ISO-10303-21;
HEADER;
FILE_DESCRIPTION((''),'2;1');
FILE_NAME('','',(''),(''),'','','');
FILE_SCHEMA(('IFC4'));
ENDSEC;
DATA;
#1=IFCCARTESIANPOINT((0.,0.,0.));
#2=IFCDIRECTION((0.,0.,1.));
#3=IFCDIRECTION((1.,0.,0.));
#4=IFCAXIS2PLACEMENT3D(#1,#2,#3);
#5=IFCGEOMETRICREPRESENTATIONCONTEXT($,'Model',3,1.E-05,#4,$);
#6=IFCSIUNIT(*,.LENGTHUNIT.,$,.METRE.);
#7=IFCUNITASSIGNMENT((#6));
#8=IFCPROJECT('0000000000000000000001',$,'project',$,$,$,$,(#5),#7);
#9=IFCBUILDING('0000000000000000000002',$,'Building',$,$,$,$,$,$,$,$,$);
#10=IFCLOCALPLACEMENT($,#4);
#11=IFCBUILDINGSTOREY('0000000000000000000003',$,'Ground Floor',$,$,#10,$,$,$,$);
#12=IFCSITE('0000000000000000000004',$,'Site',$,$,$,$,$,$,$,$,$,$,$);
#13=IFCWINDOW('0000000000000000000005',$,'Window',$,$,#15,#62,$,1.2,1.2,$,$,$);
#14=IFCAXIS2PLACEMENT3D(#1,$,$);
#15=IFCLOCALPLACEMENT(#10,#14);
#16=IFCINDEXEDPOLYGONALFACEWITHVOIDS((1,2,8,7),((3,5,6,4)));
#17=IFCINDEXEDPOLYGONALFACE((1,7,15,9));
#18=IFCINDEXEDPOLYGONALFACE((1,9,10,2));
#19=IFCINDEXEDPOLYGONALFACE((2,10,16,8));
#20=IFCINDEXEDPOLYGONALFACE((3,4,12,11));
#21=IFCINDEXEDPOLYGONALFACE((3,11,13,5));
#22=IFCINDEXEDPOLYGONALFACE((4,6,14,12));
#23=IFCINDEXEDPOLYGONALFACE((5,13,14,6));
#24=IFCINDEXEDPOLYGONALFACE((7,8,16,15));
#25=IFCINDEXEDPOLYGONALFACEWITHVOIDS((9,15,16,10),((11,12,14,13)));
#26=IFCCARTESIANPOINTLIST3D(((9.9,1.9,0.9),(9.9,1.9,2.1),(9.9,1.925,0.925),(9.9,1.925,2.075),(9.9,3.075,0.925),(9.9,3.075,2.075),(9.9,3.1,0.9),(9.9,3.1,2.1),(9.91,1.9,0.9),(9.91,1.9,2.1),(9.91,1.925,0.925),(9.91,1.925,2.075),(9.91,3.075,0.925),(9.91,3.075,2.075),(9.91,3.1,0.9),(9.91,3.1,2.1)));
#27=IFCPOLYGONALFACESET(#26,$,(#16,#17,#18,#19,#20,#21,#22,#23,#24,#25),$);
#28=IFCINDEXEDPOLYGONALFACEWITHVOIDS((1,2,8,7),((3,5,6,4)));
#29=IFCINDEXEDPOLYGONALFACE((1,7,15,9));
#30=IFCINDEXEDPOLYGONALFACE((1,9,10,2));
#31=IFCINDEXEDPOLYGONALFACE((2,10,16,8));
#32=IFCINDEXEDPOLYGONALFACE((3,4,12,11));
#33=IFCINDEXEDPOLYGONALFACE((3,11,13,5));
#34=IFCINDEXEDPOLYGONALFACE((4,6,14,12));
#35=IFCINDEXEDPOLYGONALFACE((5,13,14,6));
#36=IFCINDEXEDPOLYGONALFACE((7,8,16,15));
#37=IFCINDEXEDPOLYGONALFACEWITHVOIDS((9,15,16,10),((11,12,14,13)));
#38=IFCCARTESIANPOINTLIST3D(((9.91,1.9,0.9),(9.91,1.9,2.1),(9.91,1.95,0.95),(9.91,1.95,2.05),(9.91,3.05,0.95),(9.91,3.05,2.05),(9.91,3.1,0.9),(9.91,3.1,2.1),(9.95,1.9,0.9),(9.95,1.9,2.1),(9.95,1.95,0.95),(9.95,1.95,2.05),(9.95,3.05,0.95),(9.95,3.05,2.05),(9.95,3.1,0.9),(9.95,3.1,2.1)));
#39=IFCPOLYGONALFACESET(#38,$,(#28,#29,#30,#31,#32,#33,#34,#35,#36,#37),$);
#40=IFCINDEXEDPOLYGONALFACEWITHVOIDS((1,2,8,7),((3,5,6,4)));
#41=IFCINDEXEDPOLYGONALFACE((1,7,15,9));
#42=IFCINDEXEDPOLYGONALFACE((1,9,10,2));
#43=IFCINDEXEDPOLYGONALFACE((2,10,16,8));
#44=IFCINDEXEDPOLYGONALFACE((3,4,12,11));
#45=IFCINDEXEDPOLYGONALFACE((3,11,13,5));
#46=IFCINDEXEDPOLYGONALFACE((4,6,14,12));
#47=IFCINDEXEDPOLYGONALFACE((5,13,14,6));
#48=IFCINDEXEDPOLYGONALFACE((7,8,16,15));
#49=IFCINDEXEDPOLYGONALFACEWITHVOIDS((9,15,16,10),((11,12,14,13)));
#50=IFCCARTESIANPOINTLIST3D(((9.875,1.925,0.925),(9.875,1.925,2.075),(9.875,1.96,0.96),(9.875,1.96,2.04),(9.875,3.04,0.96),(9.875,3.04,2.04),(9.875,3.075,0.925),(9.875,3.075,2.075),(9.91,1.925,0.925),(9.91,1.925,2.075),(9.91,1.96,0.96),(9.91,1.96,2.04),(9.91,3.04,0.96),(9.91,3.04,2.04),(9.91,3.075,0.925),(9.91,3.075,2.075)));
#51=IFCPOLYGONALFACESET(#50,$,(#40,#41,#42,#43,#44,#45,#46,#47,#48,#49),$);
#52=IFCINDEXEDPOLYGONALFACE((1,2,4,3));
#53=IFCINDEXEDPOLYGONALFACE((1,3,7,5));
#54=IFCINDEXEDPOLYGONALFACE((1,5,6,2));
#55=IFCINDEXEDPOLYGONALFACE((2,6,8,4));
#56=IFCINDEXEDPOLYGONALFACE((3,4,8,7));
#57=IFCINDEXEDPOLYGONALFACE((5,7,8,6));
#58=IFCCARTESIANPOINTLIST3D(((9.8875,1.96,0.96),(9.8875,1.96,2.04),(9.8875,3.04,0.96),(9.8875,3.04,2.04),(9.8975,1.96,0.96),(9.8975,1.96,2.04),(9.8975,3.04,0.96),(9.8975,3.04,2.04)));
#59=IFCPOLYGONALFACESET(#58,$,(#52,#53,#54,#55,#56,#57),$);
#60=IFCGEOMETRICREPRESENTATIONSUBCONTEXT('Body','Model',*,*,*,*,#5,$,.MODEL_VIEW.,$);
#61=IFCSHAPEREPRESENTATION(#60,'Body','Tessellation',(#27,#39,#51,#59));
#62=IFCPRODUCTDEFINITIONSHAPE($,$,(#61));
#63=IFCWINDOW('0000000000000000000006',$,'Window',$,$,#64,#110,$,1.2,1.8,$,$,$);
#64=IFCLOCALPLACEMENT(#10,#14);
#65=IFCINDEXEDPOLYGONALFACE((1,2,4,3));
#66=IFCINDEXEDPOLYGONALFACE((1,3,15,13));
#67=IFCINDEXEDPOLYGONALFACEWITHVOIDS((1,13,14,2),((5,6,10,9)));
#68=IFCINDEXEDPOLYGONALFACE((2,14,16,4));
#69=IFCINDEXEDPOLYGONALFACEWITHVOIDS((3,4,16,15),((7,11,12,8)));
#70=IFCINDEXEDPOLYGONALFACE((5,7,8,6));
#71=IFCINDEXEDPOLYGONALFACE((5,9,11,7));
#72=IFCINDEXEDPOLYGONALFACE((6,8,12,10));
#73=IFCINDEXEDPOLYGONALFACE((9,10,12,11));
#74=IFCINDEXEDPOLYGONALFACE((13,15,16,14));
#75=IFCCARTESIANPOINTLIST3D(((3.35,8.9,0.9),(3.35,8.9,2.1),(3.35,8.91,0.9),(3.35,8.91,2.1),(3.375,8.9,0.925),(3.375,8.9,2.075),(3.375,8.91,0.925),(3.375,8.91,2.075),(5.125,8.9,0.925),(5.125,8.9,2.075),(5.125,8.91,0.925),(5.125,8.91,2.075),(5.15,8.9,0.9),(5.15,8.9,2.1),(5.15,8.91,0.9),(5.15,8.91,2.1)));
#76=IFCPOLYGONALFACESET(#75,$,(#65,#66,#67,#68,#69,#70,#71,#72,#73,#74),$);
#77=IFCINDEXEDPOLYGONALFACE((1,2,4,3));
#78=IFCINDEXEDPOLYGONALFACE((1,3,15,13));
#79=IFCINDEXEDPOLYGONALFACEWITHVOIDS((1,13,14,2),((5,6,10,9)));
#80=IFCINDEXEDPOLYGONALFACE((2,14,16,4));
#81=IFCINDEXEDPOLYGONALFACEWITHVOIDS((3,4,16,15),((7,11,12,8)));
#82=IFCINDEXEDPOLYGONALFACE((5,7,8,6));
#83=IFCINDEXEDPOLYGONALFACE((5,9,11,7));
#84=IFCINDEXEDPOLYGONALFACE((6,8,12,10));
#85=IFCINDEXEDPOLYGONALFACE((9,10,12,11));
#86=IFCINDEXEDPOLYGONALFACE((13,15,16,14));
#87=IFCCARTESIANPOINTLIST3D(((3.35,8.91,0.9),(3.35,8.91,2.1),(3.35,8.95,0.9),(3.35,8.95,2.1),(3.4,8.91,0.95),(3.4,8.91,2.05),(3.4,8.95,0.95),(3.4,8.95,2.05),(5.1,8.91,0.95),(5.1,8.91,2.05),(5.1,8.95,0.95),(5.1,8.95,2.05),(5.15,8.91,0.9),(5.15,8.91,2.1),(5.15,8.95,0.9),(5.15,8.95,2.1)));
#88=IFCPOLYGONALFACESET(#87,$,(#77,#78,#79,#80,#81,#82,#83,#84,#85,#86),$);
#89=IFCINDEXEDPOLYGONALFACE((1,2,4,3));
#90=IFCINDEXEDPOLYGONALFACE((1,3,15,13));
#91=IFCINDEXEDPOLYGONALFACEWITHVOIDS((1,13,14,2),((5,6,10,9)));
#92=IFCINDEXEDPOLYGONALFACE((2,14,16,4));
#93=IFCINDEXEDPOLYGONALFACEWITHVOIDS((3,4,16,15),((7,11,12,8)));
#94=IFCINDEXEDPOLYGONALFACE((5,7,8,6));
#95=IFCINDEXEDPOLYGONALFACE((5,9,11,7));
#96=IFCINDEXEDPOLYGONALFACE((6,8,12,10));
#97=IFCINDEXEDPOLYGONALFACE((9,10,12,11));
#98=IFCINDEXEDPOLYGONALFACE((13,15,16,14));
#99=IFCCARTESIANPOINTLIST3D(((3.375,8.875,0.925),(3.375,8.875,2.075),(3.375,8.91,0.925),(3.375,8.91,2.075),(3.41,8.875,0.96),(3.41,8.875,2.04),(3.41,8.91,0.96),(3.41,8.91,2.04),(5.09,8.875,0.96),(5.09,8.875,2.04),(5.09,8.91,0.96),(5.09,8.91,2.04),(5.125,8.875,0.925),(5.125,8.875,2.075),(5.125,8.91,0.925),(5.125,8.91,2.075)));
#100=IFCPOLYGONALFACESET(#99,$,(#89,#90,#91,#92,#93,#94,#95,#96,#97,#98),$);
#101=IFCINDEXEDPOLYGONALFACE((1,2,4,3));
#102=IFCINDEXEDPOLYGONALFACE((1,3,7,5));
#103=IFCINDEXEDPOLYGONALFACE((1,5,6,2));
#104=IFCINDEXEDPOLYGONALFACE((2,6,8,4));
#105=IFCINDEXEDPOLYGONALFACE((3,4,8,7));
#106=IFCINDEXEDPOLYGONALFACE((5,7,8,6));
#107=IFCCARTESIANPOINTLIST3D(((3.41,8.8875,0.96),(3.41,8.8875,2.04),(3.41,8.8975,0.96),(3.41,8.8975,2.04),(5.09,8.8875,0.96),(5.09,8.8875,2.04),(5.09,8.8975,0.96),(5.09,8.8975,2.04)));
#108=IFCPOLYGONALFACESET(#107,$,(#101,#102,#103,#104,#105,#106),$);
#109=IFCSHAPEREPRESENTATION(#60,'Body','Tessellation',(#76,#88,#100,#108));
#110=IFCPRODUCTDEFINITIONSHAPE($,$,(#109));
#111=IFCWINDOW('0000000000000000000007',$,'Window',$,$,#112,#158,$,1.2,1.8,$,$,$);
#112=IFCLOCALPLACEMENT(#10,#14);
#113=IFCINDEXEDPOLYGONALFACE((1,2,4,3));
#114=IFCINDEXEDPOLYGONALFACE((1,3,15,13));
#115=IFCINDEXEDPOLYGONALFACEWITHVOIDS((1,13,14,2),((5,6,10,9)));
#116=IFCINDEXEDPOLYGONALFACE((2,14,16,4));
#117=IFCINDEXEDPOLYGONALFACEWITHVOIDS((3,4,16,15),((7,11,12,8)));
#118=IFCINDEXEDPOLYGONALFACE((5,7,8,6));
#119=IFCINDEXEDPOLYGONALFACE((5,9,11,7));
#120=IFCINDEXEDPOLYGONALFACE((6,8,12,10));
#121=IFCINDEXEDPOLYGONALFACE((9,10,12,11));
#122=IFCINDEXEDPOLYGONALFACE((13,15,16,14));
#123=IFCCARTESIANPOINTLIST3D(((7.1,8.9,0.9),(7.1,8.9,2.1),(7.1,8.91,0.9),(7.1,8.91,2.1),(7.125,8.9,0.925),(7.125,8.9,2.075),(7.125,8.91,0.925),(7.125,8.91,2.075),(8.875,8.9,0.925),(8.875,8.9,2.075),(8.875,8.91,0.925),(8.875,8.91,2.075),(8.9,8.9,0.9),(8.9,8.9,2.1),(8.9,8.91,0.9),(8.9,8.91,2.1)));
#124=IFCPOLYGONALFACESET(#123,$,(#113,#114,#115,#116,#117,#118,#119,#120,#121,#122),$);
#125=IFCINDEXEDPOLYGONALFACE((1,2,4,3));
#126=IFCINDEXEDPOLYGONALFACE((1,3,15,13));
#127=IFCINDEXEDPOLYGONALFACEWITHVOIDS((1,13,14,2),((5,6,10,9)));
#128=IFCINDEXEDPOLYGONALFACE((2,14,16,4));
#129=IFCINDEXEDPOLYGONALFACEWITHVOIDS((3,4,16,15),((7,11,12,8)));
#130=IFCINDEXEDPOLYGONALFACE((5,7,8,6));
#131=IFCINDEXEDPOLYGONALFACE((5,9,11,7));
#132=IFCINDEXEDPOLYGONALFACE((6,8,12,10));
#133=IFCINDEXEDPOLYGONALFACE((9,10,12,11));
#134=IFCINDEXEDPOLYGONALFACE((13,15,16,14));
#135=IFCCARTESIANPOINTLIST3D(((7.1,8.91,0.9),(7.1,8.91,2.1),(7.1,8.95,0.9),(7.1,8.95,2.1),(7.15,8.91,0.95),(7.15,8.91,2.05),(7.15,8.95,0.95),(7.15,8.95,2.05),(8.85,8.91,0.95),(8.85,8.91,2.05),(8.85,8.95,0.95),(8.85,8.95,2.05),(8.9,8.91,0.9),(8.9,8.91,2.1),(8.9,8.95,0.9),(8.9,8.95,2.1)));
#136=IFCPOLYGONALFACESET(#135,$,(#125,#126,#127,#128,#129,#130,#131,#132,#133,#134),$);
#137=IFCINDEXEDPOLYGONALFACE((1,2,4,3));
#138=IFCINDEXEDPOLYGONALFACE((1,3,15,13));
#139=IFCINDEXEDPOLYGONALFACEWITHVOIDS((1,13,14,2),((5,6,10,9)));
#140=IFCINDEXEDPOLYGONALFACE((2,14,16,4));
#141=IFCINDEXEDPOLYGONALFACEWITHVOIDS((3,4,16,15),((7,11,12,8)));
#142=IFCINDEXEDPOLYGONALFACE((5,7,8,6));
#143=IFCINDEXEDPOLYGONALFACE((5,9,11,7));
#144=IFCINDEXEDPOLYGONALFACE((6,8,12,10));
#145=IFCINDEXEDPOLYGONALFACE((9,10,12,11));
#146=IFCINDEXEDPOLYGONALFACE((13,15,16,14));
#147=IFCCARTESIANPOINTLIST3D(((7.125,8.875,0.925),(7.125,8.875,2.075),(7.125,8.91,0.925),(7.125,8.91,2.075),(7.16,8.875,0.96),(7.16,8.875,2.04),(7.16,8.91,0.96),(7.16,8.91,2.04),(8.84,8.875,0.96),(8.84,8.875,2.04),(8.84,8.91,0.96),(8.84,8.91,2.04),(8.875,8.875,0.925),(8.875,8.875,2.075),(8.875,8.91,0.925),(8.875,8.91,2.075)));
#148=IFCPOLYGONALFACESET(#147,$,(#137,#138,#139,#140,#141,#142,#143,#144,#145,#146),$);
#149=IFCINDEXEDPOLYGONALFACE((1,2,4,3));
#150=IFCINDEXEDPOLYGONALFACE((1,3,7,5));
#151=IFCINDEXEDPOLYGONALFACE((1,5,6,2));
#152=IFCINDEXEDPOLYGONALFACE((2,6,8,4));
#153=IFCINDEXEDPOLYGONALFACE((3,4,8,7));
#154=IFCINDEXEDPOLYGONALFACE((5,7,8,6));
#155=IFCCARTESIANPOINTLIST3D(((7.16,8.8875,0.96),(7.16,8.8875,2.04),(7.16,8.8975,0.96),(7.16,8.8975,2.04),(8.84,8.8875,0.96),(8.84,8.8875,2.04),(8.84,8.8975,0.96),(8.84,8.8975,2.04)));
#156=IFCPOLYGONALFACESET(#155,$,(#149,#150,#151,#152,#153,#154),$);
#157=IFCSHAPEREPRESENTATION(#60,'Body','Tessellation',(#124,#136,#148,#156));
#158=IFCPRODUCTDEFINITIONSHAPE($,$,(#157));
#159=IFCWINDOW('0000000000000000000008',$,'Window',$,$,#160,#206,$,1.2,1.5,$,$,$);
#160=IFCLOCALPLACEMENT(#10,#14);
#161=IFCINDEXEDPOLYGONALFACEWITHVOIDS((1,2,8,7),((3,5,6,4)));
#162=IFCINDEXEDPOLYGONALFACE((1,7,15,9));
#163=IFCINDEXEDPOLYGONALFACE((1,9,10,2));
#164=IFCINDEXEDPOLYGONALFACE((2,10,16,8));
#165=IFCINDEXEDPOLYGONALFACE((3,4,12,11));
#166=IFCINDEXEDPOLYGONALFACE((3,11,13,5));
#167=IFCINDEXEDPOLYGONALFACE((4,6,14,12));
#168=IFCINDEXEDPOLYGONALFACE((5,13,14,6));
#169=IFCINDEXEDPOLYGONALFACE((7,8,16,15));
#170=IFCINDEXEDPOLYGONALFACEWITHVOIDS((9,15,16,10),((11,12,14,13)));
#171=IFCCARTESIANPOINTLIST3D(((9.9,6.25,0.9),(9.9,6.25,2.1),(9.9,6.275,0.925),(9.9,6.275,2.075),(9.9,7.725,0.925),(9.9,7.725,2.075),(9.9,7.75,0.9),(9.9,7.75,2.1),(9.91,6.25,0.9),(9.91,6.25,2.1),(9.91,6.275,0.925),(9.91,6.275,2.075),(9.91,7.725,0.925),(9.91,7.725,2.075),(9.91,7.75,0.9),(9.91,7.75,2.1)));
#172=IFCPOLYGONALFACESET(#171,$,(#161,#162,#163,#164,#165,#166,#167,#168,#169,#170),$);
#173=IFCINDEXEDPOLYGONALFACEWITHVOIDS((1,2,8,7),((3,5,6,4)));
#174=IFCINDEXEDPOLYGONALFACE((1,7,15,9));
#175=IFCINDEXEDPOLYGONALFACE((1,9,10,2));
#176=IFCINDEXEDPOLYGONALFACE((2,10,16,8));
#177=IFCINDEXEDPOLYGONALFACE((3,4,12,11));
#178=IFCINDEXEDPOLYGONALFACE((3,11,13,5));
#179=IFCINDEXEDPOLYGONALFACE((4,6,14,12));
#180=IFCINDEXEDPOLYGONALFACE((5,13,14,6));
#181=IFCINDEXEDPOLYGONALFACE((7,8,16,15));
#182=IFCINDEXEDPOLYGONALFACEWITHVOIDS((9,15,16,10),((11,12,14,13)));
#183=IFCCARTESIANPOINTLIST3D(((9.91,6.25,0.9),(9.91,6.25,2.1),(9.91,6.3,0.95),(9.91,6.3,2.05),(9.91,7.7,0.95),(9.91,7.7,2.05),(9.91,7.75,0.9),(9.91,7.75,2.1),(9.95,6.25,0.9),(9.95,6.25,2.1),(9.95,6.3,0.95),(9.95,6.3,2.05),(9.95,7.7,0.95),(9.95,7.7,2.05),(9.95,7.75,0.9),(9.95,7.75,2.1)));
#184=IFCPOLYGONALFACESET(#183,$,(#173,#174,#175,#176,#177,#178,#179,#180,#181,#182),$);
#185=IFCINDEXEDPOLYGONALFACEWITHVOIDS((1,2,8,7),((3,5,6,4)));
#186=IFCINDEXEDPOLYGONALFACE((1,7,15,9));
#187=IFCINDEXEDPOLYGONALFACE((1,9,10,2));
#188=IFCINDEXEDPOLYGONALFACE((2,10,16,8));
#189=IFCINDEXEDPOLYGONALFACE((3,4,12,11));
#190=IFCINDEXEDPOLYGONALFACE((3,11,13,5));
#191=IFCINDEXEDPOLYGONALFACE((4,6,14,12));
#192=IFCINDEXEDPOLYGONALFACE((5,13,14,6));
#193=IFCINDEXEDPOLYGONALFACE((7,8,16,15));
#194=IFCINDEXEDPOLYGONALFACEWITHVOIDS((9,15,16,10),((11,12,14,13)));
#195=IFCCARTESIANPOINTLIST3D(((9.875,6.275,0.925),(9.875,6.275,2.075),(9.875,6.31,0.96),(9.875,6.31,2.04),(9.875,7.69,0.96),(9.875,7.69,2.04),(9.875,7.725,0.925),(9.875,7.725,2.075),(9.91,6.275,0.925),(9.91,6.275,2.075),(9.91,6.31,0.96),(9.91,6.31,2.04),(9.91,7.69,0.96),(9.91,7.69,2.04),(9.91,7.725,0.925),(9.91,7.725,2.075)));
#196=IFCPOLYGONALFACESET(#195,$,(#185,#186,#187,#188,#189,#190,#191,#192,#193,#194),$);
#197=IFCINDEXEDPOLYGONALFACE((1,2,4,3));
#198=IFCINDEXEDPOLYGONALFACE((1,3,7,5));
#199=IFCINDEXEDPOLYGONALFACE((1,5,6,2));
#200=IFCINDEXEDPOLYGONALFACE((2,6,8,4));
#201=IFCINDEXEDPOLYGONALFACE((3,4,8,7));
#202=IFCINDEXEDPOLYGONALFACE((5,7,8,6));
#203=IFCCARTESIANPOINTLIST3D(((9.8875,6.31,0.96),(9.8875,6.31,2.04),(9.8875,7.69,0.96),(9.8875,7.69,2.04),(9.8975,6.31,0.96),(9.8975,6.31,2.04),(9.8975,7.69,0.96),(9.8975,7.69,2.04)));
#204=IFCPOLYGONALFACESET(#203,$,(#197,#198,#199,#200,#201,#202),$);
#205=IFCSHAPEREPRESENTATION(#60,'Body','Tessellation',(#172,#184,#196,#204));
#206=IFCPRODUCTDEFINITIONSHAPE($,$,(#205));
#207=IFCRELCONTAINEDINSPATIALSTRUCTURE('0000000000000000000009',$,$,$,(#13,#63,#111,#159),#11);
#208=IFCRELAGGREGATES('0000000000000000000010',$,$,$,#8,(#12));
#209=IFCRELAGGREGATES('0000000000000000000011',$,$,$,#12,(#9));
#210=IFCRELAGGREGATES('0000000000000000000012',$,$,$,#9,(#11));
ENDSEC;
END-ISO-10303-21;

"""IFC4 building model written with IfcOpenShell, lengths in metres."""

from ifc_helpers import new_model, si_unit, frame, origin_with_axes, place, context, subcontext, project, spatial, line, indexed_curve, outline, extrude, element, save


model = new_model("IFC4")

# Units and contexts
model_context = context("Model", 3, precision=1e-05, world=origin_with_axes())
body_context = subcontext(model_context, "Body", "Model", "MODEL_VIEW")
ifc_project = project(units=[si_unit("LENGTHUNIT", "METRE")], contexts=[model_context])

# Site, building, storey
site = spatial("IfcSite", under=ifc_project, Name="Site")
building = spatial("IfcBuilding", under=site, Name="Building")
storey_placement = place(None, origin_with_axes())
storey = spatial("IfcBuildingStorey", under=building, at=storey_placement, Name="Ground Floor")

# Windows
for number, where, z_axis, x_axis, name in (
    (1, (10.0, 1.9, 0.9), (0.0, 0.0, 1.0), (0.0, 1.0, 0.0), "Window"),
):
    element("IfcWindow", number, at=place(storey_placement, frame(where, z_axis=z_axis, x_axis=x_axis)), inside=storey, Name=name, OverallHeight=1.2, OverallWidth=1.2, context=body_context, shape_type="SweptSolid", body=[
        extrude(outline(indexed_curve([(0.0, 0.0), (1.2, 0.0), (1.2, 1.2), (0.0, 1.2)], segments=[line(1, 2, 3, 4, 1)]), holes=[indexed_curve([(0.025, 0.025), (1.175, 0.025), (1.175, 1.175), (0.025, 1.175)], segments=[line(1, 2, 3, 4, 1)])]), frame((0.0, 0.09, 0.0), z_axis=(0.0, -1.0, 0.0), x_axis=(1.0, 0.0, 0.0)), (0.0, 0.0, -1.0), 0.01),
        extrude(outline(indexed_curve([(0.0, 0.0), (1.2, 0.0), (1.2, 1.2), (0.0, 1.2)], segments=[line(1, 2, 3, 4, 1)]), holes=[indexed_curve([(0.05, 0.05), (1.15, 0.05), (1.15, 1.15), (0.05, 1.15)], segments=[line(1, 2, 3, 4, 1)])]), frame((0.0, 0.05, 0.0), z_axis=(0.0, -1.0, 0.0), x_axis=(1.0, 0.0, 0.0)), (0.0, 0.0, -1.0), 0.04),
        extrude(outline(indexed_curve([(0.0, 0.0), (1.15, 0.0), (1.15, 1.15), (0.0, 1.15)], segments=[line(1, 2, 3, 4, 1)]), holes=[indexed_curve([(0.035, 0.035), (1.115, 0.035), (1.115, 1.115), (0.035, 1.115)], segments=[line(1, 2, 3, 4, 1)])]), frame((0.025, 0.09, 0.025), z_axis=(0.0, -1.0, 0.0), x_axis=(1.0, 0.0, 0.0)), (0.0, 0.0, -1.0), 0.035),
        extrude(outline(indexed_curve([(0.035, 0.035), (1.115, 0.035), (1.115, 1.115), (0.035, 1.115)], segments=[line(1, 2, 3, 4, 1)])), frame((0.025, 0.1025, 0.025), z_axis=(0.0, -1.0, 0.0), x_axis=(1.0, 0.0, 0.0)), (0.0, 0.0, -1.0), 0.01),
    ])
for number, where, z_axis, x_axis, name in (
    (2, (5.15, 9.0, 0.9), (0.0, 0.0, 1.0), (-1.0, 0.0, 0.0), "Window"),
    (3, (8.9, 9.0, 0.9), (0.0, 0.0, 1.0), (-1.0, 0.0, 0.0), "Window"),
):
    element("IfcWindow", number, at=place(storey_placement, frame(where, z_axis=z_axis, x_axis=x_axis)), inside=storey, Name=name, OverallHeight=1.2, OverallWidth=1.8, context=body_context, shape_type="SweptSolid", body=[
        extrude(outline(indexed_curve([(0.0, 0.0), (1.8, 0.0), (1.8, 1.2), (0.0, 1.2)], segments=[line(1, 2, 3, 4, 1)]), holes=[indexed_curve([(0.025, 0.025), (1.775, 0.025), (1.775, 1.175), (0.025, 1.175)], segments=[line(1, 2, 3, 4, 1)])]), frame((0.0, 0.09, 0.0), z_axis=(0.0, -1.0, 0.0), x_axis=(1.0, 0.0, 0.0)), (0.0, 0.0, -1.0), 0.01),
        extrude(outline(indexed_curve([(0.0, 0.0), (1.8, 0.0), (1.8, 1.2), (0.0, 1.2)], segments=[line(1, 2, 3, 4, 1)]), holes=[indexed_curve([(0.05, 0.05), (1.75, 0.05), (1.75, 1.15), (0.05, 1.15)], segments=[line(1, 2, 3, 4, 1)])]), frame((0.0, 0.05, 0.0), z_axis=(0.0, -1.0, 0.0), x_axis=(1.0, 0.0, 0.0)), (0.0, 0.0, -1.0), 0.04),
        extrude(outline(indexed_curve([(0.0, 0.0), (1.75, 0.0), (1.75, 1.15), (0.0, 1.15)], segments=[line(1, 2, 3, 4, 1)]), holes=[indexed_curve([(0.035, 0.035), (1.715, 0.035), (1.715, 1.115), (0.035, 1.115)], segments=[line(1, 2, 3, 4, 1)])]), frame((0.025, 0.09, 0.025), z_axis=(0.0, -1.0, 0.0), x_axis=(1.0, 0.0, 0.0)), (0.0, 0.0, -1.0), 0.035),
        extrude(outline(indexed_curve([(0.035, 0.035), (1.715, 0.035), (1.715, 1.115), (0.035, 1.115)], segments=[line(1, 2, 3, 4, 1)])), frame((0.025, 0.1025, 0.025), z_axis=(0.0, -1.0, 0.0), x_axis=(1.0, 0.0, 0.0)), (0.0, 0.0, -1.0), 0.01),
    ])
window_1_placement = place(storey_placement, frame((10.0, 6.25, 0.9), z_axis=(0.0, 0.0, 1.0), x_axis=(0.0, 1.0, 0.0)))
element("IfcWindow", 4, at=window_1_placement, inside=storey, Name="Window", OverallHeight=1.2, OverallWidth=1.5, context=body_context, shape_type="SweptSolid", body=[
    extrude(outline(indexed_curve([(0.0, 0.0), (1.5, 0.0), (1.5, 1.2), (0.0, 1.2)], segments=[line(1, 2, 3, 4, 1)]), holes=[indexed_curve([(0.025, 0.025), (1.475, 0.025), (1.475, 1.175), (0.025, 1.175)], segments=[line(1, 2, 3, 4, 1)])]), frame((0.0, 0.09, 0.0), z_axis=(0.0, -1.0, 0.0), x_axis=(1.0, 0.0, 0.0)), (0.0, 0.0, -1.0), 0.01),
    extrude(outline(indexed_curve([(0.0, 0.0), (1.5, 0.0), (1.5, 1.2), (0.0, 1.2)], segments=[line(1, 2, 3, 4, 1)]), holes=[indexed_curve([(0.05, 0.05), (1.45, 0.05), (1.45, 1.15), (0.05, 1.15)], segments=[line(1, 2, 3, 4, 1)])]), frame((0.0, 0.05, 0.0), z_axis=(0.0, -1.0, 0.0), x_axis=(1.0, 0.0, 0.0)), (0.0, 0.0, -1.0), 0.04),
    extrude(outline(indexed_curve([(0.0, 0.0), (1.45, 0.0), (1.45, 1.15), (0.0, 1.15)], segments=[line(1, 2, 3, 4, 1)]), holes=[indexed_curve([(0.035, 0.035), (1.415, 0.035), (1.415, 1.115), (0.035, 1.115)], segments=[line(1, 2, 3, 4, 1)])]), frame((0.025, 0.09, 0.025), z_axis=(0.0, -1.0, 0.0), x_axis=(1.0, 0.0, 0.0)), (0.0, 0.0, -1.0), 0.035),
    extrude(outline(indexed_curve([(0.035, 0.035), (1.415, 0.035), (1.415, 1.115), (0.035, 1.115)], segments=[line(1, 2, 3, 4, 1)])), frame((0.025, 0.1025, 0.025), z_axis=(0.0, -1.0, 0.0), x_axis=(1.0, 0.0, 0.0)), (0.0, 0.0, -1.0), 0.01),
])

save(model, "model.ifc")
